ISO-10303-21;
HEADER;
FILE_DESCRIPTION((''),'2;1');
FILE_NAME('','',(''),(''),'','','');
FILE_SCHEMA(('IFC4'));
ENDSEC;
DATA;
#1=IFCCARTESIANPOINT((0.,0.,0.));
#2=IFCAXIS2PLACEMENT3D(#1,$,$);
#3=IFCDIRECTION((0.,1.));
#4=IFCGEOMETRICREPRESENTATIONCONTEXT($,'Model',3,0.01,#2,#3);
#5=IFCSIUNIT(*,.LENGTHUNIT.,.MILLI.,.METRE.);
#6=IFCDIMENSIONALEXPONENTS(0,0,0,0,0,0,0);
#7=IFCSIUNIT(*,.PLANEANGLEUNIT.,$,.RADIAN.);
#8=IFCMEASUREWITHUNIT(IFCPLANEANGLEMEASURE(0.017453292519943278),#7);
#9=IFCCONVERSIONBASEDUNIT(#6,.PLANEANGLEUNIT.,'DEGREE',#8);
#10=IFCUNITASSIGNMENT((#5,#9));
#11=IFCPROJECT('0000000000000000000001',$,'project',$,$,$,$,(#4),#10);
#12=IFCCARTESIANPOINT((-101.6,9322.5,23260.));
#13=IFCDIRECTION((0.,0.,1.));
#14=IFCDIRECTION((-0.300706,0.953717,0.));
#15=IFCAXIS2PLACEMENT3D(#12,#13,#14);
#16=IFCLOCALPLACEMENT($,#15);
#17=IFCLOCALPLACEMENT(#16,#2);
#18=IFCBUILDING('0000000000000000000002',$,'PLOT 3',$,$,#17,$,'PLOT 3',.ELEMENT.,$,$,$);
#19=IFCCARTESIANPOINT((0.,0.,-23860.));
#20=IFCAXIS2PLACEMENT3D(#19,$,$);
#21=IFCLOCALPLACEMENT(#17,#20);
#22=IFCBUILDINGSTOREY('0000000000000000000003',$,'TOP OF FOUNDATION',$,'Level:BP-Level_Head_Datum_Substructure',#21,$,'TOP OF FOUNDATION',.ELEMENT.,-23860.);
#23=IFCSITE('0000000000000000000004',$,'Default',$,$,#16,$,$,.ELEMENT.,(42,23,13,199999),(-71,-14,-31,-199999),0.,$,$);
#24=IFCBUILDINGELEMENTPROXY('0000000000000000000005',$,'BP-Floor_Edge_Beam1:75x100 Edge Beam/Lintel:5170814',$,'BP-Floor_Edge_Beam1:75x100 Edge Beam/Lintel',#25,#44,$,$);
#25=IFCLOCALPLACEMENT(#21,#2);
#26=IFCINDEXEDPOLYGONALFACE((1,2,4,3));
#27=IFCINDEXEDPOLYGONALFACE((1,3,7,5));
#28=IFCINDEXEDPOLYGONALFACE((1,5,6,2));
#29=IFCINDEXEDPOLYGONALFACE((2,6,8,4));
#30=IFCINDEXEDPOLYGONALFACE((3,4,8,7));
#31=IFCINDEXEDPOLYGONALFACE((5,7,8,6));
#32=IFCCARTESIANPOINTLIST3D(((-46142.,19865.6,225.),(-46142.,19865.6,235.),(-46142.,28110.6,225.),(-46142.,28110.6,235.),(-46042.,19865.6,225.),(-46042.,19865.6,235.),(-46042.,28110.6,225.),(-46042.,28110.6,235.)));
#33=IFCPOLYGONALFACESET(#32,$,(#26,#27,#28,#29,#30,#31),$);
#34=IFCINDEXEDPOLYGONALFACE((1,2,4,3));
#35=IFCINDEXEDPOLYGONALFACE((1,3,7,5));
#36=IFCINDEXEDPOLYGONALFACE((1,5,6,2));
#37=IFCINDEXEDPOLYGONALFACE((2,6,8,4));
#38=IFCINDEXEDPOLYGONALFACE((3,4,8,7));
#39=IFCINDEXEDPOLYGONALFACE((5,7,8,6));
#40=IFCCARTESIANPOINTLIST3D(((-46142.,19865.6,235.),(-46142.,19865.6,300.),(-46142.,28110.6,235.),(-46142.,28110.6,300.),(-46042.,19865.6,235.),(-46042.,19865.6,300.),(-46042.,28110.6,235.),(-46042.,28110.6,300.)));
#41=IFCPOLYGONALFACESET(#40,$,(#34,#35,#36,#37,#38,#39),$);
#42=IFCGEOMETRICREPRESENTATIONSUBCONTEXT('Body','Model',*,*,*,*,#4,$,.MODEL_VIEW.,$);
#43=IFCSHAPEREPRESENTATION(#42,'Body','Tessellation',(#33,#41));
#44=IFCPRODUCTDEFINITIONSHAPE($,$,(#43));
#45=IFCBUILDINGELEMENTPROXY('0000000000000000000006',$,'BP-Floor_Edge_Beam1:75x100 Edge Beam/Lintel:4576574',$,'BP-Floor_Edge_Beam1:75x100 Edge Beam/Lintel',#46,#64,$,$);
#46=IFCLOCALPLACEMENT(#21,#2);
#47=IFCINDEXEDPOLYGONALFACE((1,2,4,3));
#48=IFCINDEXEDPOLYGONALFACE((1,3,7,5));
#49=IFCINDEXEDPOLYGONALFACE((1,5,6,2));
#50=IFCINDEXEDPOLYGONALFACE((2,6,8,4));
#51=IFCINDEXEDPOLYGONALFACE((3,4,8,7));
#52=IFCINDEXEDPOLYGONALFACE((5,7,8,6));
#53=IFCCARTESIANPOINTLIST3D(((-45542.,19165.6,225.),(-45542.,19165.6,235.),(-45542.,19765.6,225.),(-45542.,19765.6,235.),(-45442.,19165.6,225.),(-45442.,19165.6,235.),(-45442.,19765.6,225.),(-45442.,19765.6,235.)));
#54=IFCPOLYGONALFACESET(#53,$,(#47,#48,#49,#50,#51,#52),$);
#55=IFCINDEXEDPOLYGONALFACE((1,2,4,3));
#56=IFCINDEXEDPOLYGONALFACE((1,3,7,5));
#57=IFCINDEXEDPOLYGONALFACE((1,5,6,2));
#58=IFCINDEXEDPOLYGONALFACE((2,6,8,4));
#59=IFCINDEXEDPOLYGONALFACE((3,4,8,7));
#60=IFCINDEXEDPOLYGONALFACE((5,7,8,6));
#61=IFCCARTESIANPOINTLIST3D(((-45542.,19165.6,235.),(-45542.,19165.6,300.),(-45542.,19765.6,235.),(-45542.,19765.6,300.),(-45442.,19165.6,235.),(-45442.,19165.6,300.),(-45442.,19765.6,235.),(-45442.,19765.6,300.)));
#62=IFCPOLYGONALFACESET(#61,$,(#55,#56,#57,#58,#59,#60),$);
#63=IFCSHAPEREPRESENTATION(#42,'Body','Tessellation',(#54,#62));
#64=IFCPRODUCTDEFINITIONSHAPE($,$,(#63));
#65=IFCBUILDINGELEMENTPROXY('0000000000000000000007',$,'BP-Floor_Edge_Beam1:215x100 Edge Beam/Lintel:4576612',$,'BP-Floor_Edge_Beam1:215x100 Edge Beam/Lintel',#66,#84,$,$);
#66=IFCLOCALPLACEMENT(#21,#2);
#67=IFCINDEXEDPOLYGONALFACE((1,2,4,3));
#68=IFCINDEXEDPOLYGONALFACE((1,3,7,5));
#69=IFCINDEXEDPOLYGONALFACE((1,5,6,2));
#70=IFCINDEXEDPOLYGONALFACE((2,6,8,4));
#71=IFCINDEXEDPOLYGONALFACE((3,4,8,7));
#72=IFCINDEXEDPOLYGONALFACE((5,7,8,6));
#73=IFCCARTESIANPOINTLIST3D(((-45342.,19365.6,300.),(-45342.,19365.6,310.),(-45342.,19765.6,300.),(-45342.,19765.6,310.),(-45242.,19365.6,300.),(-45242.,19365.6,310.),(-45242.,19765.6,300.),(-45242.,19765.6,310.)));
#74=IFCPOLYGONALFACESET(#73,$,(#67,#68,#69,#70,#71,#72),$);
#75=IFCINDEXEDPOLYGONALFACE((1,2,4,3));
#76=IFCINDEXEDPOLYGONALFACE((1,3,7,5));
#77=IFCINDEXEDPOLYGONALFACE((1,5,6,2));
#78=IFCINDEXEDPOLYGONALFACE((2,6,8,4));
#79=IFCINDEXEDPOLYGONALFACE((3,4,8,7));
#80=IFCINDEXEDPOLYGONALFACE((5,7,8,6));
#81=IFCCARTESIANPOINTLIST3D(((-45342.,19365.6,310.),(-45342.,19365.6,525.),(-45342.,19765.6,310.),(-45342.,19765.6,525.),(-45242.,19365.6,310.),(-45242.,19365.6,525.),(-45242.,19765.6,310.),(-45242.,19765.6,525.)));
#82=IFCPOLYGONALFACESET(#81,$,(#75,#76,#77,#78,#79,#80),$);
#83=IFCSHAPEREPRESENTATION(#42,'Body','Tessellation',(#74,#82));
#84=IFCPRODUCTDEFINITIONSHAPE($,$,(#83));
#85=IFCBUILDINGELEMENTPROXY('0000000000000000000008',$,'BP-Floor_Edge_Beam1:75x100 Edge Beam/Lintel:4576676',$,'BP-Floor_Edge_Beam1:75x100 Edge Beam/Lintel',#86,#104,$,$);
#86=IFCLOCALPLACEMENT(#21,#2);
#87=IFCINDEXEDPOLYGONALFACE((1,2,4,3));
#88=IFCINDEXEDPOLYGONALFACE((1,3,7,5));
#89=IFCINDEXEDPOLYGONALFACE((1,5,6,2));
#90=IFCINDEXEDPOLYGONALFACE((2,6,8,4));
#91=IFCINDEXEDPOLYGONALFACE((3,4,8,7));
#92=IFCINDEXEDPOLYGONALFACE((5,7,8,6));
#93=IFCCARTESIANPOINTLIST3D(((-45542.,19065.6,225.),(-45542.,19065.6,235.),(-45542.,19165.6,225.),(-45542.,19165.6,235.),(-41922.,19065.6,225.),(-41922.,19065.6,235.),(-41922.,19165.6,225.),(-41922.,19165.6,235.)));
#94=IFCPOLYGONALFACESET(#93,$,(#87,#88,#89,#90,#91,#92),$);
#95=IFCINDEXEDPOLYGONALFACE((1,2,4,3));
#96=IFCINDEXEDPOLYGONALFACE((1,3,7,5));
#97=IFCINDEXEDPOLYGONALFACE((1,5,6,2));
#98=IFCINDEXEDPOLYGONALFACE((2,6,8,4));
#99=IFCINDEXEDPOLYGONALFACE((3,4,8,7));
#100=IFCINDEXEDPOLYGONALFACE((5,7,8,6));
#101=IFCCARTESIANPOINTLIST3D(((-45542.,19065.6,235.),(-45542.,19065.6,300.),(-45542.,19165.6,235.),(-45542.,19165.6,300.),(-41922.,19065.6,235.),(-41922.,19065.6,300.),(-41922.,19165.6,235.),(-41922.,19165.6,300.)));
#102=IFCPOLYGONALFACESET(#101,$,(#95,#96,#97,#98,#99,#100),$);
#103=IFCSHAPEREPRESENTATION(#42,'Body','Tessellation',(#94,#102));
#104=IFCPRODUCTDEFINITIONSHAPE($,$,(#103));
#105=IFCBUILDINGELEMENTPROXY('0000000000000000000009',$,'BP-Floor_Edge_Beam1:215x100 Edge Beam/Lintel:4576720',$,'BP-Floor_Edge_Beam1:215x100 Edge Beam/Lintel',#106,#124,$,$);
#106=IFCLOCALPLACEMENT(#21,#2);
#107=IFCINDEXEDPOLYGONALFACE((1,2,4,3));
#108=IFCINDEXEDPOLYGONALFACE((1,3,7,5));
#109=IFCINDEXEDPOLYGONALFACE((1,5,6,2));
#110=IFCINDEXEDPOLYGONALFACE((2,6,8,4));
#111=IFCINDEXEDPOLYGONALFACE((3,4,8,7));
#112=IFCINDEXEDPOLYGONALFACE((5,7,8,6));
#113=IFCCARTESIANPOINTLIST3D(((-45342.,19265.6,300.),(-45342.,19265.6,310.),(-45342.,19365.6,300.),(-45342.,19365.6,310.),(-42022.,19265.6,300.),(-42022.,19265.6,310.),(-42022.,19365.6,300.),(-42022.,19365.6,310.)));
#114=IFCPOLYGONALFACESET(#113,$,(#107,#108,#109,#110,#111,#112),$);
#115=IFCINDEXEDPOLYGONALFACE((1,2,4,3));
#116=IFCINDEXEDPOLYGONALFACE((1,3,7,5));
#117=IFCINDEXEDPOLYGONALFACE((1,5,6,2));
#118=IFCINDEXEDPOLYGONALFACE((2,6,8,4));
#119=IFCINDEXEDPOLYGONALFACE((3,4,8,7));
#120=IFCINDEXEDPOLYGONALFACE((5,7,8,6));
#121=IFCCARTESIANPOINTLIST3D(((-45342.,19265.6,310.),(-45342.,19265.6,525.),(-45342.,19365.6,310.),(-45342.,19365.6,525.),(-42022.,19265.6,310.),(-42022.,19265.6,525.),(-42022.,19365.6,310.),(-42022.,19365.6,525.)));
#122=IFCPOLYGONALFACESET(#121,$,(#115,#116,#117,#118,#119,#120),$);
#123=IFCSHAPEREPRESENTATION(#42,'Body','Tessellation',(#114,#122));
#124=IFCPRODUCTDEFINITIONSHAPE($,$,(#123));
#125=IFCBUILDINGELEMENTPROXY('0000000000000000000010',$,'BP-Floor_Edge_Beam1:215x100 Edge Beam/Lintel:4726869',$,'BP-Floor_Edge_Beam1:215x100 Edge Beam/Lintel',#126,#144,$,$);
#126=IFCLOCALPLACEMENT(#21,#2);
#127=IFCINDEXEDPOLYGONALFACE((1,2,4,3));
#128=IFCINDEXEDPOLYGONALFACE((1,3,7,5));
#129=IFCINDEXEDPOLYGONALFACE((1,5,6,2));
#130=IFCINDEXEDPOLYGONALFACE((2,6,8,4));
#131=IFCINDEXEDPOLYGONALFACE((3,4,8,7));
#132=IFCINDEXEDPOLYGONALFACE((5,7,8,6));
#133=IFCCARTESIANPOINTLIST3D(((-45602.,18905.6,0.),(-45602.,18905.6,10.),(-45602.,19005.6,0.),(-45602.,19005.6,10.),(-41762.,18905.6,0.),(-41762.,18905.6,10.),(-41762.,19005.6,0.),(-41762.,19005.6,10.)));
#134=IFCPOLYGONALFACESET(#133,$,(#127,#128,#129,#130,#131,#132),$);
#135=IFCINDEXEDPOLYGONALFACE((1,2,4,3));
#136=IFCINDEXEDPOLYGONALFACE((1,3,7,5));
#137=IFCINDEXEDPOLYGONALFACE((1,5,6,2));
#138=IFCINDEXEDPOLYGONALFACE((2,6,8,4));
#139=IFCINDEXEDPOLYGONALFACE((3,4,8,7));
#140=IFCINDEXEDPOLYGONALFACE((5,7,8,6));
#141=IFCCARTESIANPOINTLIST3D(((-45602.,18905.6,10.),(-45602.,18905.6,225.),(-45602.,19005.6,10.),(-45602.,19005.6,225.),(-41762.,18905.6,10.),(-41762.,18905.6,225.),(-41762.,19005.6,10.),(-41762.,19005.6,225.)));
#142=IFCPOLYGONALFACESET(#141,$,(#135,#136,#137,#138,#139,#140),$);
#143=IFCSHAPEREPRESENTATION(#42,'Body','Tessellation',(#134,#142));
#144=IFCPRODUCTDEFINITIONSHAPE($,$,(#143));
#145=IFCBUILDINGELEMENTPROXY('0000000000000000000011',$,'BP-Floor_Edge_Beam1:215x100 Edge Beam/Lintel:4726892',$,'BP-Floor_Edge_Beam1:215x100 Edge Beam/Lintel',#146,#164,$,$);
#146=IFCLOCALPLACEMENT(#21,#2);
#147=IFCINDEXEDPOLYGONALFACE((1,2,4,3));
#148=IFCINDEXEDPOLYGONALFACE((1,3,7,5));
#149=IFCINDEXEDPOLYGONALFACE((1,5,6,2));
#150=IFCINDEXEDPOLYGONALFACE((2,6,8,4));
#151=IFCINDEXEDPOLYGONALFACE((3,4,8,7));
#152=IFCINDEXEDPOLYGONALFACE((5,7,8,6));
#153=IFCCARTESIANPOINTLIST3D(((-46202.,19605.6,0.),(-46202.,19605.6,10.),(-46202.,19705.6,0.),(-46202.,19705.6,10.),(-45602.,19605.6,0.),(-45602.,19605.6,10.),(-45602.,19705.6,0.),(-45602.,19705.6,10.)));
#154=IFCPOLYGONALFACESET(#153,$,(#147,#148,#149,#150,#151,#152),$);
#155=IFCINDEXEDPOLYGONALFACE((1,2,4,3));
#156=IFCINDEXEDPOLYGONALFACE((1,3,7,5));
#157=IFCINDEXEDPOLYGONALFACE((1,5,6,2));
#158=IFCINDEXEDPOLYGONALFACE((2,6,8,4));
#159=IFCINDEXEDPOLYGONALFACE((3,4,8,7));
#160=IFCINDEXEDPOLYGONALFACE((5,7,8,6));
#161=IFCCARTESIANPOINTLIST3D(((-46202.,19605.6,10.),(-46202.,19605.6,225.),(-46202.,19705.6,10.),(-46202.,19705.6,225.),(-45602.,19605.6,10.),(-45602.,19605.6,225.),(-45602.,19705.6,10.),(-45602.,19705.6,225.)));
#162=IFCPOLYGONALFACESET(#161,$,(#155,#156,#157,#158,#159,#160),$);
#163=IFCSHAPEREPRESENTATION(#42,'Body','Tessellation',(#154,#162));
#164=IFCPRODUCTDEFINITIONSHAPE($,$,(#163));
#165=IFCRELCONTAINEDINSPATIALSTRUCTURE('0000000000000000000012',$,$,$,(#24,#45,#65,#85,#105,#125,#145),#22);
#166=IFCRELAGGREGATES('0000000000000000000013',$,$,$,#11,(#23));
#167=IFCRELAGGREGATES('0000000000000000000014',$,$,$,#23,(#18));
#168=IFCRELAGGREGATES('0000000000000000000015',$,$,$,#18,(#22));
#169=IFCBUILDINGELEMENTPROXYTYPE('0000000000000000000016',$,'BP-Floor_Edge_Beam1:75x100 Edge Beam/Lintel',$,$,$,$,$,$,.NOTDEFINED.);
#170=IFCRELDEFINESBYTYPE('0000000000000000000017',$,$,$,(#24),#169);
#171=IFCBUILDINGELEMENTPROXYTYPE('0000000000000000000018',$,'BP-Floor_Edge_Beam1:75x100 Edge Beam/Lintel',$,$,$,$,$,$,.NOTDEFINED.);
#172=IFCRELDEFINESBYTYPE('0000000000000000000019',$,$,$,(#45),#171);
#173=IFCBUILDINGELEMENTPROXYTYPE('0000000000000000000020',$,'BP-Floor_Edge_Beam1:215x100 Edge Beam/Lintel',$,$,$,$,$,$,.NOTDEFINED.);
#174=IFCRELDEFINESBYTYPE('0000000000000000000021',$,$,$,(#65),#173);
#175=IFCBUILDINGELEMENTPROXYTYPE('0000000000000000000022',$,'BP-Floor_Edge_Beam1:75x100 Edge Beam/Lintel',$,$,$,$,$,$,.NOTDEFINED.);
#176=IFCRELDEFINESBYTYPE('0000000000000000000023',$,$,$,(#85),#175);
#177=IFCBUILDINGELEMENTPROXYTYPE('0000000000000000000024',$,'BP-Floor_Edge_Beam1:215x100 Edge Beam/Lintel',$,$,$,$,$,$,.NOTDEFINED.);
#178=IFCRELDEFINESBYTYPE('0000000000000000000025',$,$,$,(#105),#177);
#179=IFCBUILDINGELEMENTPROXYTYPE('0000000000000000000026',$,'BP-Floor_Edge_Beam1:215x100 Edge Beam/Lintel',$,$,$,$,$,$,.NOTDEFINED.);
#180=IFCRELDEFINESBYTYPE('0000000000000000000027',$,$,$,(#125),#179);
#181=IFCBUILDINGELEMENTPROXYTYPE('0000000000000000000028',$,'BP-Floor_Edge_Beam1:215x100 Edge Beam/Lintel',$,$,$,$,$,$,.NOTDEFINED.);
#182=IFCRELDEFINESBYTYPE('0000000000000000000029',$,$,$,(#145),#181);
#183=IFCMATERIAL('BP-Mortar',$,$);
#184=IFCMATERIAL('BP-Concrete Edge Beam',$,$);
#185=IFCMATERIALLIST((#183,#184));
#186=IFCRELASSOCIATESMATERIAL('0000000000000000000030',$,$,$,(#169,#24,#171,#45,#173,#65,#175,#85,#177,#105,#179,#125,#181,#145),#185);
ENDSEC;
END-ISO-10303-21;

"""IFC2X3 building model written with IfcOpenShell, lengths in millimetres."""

from ifc_helpers import new_model, entity, si_unit, converted_unit, direction, frame, frame_2d, origin, origin_2d_with_axis, place, context, subcontext, project, spatial, rectangle, extrude, source, transform, mapped, material, material_list, type_object, type_shapes, element, save


model = new_model("IFC2X3")

# Units and contexts
model_context = context("Model", 3, precision=0.01, world=origin(), true_north=direction((0.0, 1.0)))
body_context = subcontext(model_context, "Body", "Model", "MODEL_VIEW")
ifc_project = project(units=[si_unit("LENGTHUNIT", "METRE", prefix="MILLI"), converted_unit("PLANEANGLEUNIT", "DEGREE", entity("IfcPlaneAngleMeasure", 0.017453292519943278), si_unit("PLANEANGLEUNIT", "RADIAN"), dimensions=[0, 0, 0, 0, 0, 0, 0])], contexts=[model_context])

# Site, building, storey
site_placement = place(None, frame((-101.6, 9322.5, 23260.0), z_axis=(0.0, 0.0, 1.0), x_axis=(-0.300706, 0.953717, 0.0)))
site = spatial("IfcSite", under=ifc_project, at=site_placement, Name="Default", CompositionType="ELEMENT", RefLatitude=(42, 23, 13, 199999), RefLongitude=(-71, -14, -31, -199999), RefElevation=0.0)
building_placement = place(site_placement, origin())
building = spatial("IfcBuilding", under=site, at=building_placement, Name="PLOT 3", LongName="PLOT 3", CompositionType="ELEMENT")
storey_placement = place(building_placement, frame((0.0, 0.0, -23860.0)))
storey = spatial("IfcBuildingStorey", under=building, at=storey_placement, Name="TOP OF FOUNDATION", ObjectType="Level:BP-Level_Head_Datum_Substructure", LongName="TOP OF FOUNDATION", CompositionType="ELEMENT", Elevation=-23860.0)

# Building element proxies
ifc_material_1 = material(Name="BP-Mortar")
ifc_material_2 = material(Name="BP-Concrete Edge Beam")
ifc_material_list = material_list([ifc_material_1, ifc_material_2])
building_element_proxy_type_1 = type_object("IfcBuildingElementProxyType", Name="BP-Floor_Edge_Beam1:75x100 Edge Beam/Lintel", PredefinedType="NOTDEFINED", material=ifc_material_list)
shared_shape_1 = source(origin(), body_context, "Body", "SweptSolid", [
    extrude(rectangle(XDim=100.0, YDim=8245.0, at=origin_2d_with_axis()), frame((0.0, 0.0, 0.0), z_axis=(0.0, 0.0, 1.0), x_axis=(0.0, 1.0, 0.0)), (0.0, 0.0, 1.0), 10.0),
    extrude(rectangle(XDim=100.0, YDim=8245.0, at=origin_2d_with_axis()), frame((0.0, 0.0, 10.0), z_axis=(0.0, 0.0, 1.0), x_axis=(0.0, 1.0, 0.0)), (0.0, 0.0, 1.0), 65.0),
])
type_shapes(building_element_proxy_type_1, [shared_shape_1])
proxy_1_placement = place(storey_placement, frame((-46092.0, 23988.1, 225.0), z_axis=(0.0, 0.0, 1.0), x_axis=(0.0, 1.0, 0.0)))
element("IfcBuildingElementProxy", 1, at=proxy_1_placement, inside=storey, type_object=building_element_proxy_type_1, material=ifc_material_list, Name="BP-Floor_Edge_Beam1:75x100 Edge Beam/Lintel:5170814", ObjectType="BP-Floor_Edge_Beam1:75x100 Edge Beam/Lintel", context=body_context, shape_type="MappedRepresentation", body=[
    mapped(shared_shape_1, transform((0.0, 0.0, 0.0), scale=1.0)),
])
building_element_proxy_type_2 = type_object("IfcBuildingElementProxyType", Name="BP-Floor_Edge_Beam1:75x100 Edge Beam/Lintel", PredefinedType="NOTDEFINED", material=ifc_material_list)
shared_shape_2 = source(origin(), body_context, "Body", "SweptSolid", [
    extrude(rectangle(XDim=100.0, YDim=600.0, at=frame_2d((0.0, 0.0), x_axis=(1.0, 0.0))), frame((0.0, 0.0, 0.0), z_axis=(0.0, 0.0, 1.0), x_axis=(0.0, 1.0, 0.0)), (0.0, 0.0, 1.0), 10.0),
    extrude(rectangle(XDim=100.0, YDim=600.0, at=origin_2d_with_axis()), frame((0.0, 0.0, 10.0), z_axis=(0.0, 0.0, 1.0), x_axis=(0.0, 1.0, 0.0)), (0.0, 0.0, 1.0), 65.0),
])
type_shapes(building_element_proxy_type_2, [shared_shape_2])
proxy_2_placement = place(storey_placement, frame((-45492.0, 19465.6, 225.0), z_axis=(0.0, 0.0, 1.0), x_axis=(0.0, 1.0, 0.0)))
element("IfcBuildingElementProxy", 2, at=proxy_2_placement, inside=storey, type_object=building_element_proxy_type_2, material=ifc_material_list, Name="BP-Floor_Edge_Beam1:75x100 Edge Beam/Lintel:4576574", ObjectType="BP-Floor_Edge_Beam1:75x100 Edge Beam/Lintel", context=body_context, shape_type="MappedRepresentation", body=[
    mapped(shared_shape_2, transform((0.0, 0.0, 0.0), scale=1.0)),
])
building_element_proxy_type_3 = type_object("IfcBuildingElementProxyType", Name="BP-Floor_Edge_Beam1:215x100 Edge Beam/Lintel", PredefinedType="NOTDEFINED", material=ifc_material_list)
shared_shape_3 = source(origin(), body_context, "Body", "SweptSolid", [
    extrude(rectangle(XDim=100.0, YDim=400.0, at=frame_2d((0.0, 0.0), x_axis=(1.0, 0.0))), frame((0.0, 0.0, 0.0), z_axis=(0.0, 0.0, 1.0), x_axis=(0.0, 1.0, 0.0)), (0.0, 0.0, 1.0), 10.0),
    extrude(rectangle(XDim=100.0, YDim=400.0, at=origin_2d_with_axis()), frame((0.0, 0.0, 10.0), z_axis=(0.0, 0.0, 1.0), x_axis=(0.0, 1.0, 0.0)), (0.0, 0.0, 1.0), 215.0),
])
type_shapes(building_element_proxy_type_3, [shared_shape_3])
proxy_3_placement = place(storey_placement, frame((-45292.0, 19565.6, 300.0), z_axis=(0.0, 0.0, 1.0), x_axis=(0.0, 1.0, 0.0)))
element("IfcBuildingElementProxy", 3, at=proxy_3_placement, inside=storey, type_object=building_element_proxy_type_3, material=ifc_material_list, Name="BP-Floor_Edge_Beam1:215x100 Edge Beam/Lintel:4576612", ObjectType="BP-Floor_Edge_Beam1:215x100 Edge Beam/Lintel", context=body_context, shape_type="MappedRepresentation", body=[
    mapped(shared_shape_3, transform((0.0, 0.0, 0.0), scale=1.0)),
])
building_element_proxy_type_4 = type_object("IfcBuildingElementProxyType", Name="BP-Floor_Edge_Beam1:75x100 Edge Beam/Lintel", PredefinedType="NOTDEFINED", material=ifc_material_list)
shared_shape_4 = source(origin(), body_context, "Body", "SweptSolid", [
    extrude(rectangle(XDim=100.0, YDim=3620.0, at=origin_2d_with_axis()), frame((0.0, 0.0, 0.0), z_axis=(0.0, 0.0, 1.0), x_axis=(0.0, 1.0, 0.0)), (0.0, 0.0, 1.0), 10.0),
    extrude(rectangle(XDim=100.0, YDim=3620.0, at=origin_2d_with_axis()), frame((0.0, 0.0, 10.0), z_axis=(0.0, 0.0, 1.0), x_axis=(0.0, 1.0, 0.0)), (0.0, 0.0, 1.0), 65.0),
])
type_shapes(building_element_proxy_type_4, [shared_shape_4])
proxy_4_placement = place(storey_placement, frame((-43732.0, 19115.6, 225.0), z_axis=(0.0, 0.0, 1.0), x_axis=(-1.0, 0.0, 0.0)))
element("IfcBuildingElementProxy", 4, at=proxy_4_placement, inside=storey, type_object=building_element_proxy_type_4, material=ifc_material_list, Name="BP-Floor_Edge_Beam1:75x100 Edge Beam/Lintel:4576676", ObjectType="BP-Floor_Edge_Beam1:75x100 Edge Beam/Lintel", context=body_context, shape_type="MappedRepresentation", body=[
    mapped(shared_shape_4, transform((0.0, 0.0, 0.0), scale=1.0)),
])
building_element_proxy_type_5 = type_object("IfcBuildingElementProxyType", Name="BP-Floor_Edge_Beam1:215x100 Edge Beam/Lintel", PredefinedType="NOTDEFINED", material=ifc_material_list)
shared_shape_5 = source(origin(), body_context, "Body", "SweptSolid", [
    extrude(rectangle(XDim=100.0, YDim=3320.0, at=origin_2d_with_axis()), frame((0.0, 0.0, 0.0), z_axis=(0.0, 0.0, 1.0), x_axis=(0.0, 1.0, 0.0)), (0.0, 0.0, 1.0), 10.0),
    extrude(rectangle(XDim=100.0, YDim=3320.0, at=origin_2d_with_axis()), frame((0.0, 0.0, 10.0), z_axis=(0.0, 0.0, 1.0), x_axis=(0.0, 1.0, 0.0)), (0.0, 0.0, 1.0), 215.0),
])
type_shapes(building_element_proxy_type_5, [shared_shape_5])
proxy_5_placement = place(storey_placement, frame((-43682.0, 19315.6, 300.0), z_axis=(0.0, 0.0, 1.0), x_axis=(-1.0, 0.0, 0.0)))
element("IfcBuildingElementProxy", 5, at=proxy_5_placement, inside=storey, type_object=building_element_proxy_type_5, material=ifc_material_list, Name="BP-Floor_Edge_Beam1:215x100 Edge Beam/Lintel:4576720", ObjectType="BP-Floor_Edge_Beam1:215x100 Edge Beam/Lintel", context=body_context, shape_type="MappedRepresentation", body=[
    mapped(shared_shape_5, transform((0.0, 0.0, 0.0), scale=1.0)),
])
building_element_proxy_type_6 = type_object("IfcBuildingElementProxyType", Name="BP-Floor_Edge_Beam1:215x100 Edge Beam/Lintel", PredefinedType="NOTDEFINED", material=ifc_material_list)
shared_shape_6 = source(origin(), body_context, "Body", "SweptSolid", [
    extrude(rectangle(XDim=100.0, YDim=3840.0, at=origin_2d_with_axis()), frame((0.0, 0.0, 0.0), z_axis=(0.0, 0.0, 1.0), x_axis=(0.0, 1.0, 0.0)), (0.0, 0.0, 1.0), 10.0),
    extrude(rectangle(XDim=100.0, YDim=3840.0, at=origin_2d_with_axis()), frame((0.0, 0.0, 10.0), z_axis=(0.0, 0.0, 1.0), x_axis=(0.0, 1.0, 0.0)), (0.0, 0.0, 1.0), 215.0),
])
type_shapes(building_element_proxy_type_6, [shared_shape_6])
proxy_6_placement = place(storey_placement, frame((-43682.0, 18955.6, 0.0), z_axis=(0.0, 0.0, 1.0), x_axis=(-1.0, 0.0, 0.0)))
element("IfcBuildingElementProxy", 6, at=proxy_6_placement, inside=storey, type_object=building_element_proxy_type_6, material=ifc_material_list, Name="BP-Floor_Edge_Beam1:215x100 Edge Beam/Lintel:4726869", ObjectType="BP-Floor_Edge_Beam1:215x100 Edge Beam/Lintel", context=body_context, shape_type="MappedRepresentation", body=[
    mapped(shared_shape_6, transform((0.0, 0.0, 0.0), scale=1.0)),
])
building_element_proxy_type_7 = type_object("IfcBuildingElementProxyType", Name="BP-Floor_Edge_Beam1:215x100 Edge Beam/Lintel", PredefinedType="NOTDEFINED", material=ifc_material_list)
shared_shape_7 = source(origin(), body_context, "Body", "SweptSolid", [
    extrude(rectangle(XDim=100.0, YDim=600.0, at=frame_2d((0.0, 0.0), x_axis=(1.0, 0.0))), frame((0.0, 0.0, 0.0), z_axis=(0.0, 0.0, 1.0), x_axis=(0.0, 1.0, 0.0)), (0.0, 0.0, 1.0), 10.0),
    extrude(rectangle(XDim=100.0, YDim=600.0, at=origin_2d_with_axis()), frame((0.0, 0.0, 10.0), z_axis=(0.0, 0.0, 1.0), x_axis=(0.0, 1.0, 0.0)), (0.0, 0.0, 1.0), 215.0),
])
type_shapes(building_element_proxy_type_7, [shared_shape_7])
proxy_7_placement = place(storey_placement, frame((-45902.0, 19655.6, 0.0), z_axis=(0.0, 0.0, 1.0), x_axis=(-1.0, 0.0, 0.0)))
element("IfcBuildingElementProxy", 7, at=proxy_7_placement, inside=storey, type_object=building_element_proxy_type_7, material=ifc_material_list, Name="BP-Floor_Edge_Beam1:215x100 Edge Beam/Lintel:4726892", ObjectType="BP-Floor_Edge_Beam1:215x100 Edge Beam/Lintel", context=body_context, shape_type="MappedRepresentation", body=[
    mapped(shared_shape_7, transform((0.0, 0.0, 0.0), scale=1.0)),
])

save(model, "model.ifc")
